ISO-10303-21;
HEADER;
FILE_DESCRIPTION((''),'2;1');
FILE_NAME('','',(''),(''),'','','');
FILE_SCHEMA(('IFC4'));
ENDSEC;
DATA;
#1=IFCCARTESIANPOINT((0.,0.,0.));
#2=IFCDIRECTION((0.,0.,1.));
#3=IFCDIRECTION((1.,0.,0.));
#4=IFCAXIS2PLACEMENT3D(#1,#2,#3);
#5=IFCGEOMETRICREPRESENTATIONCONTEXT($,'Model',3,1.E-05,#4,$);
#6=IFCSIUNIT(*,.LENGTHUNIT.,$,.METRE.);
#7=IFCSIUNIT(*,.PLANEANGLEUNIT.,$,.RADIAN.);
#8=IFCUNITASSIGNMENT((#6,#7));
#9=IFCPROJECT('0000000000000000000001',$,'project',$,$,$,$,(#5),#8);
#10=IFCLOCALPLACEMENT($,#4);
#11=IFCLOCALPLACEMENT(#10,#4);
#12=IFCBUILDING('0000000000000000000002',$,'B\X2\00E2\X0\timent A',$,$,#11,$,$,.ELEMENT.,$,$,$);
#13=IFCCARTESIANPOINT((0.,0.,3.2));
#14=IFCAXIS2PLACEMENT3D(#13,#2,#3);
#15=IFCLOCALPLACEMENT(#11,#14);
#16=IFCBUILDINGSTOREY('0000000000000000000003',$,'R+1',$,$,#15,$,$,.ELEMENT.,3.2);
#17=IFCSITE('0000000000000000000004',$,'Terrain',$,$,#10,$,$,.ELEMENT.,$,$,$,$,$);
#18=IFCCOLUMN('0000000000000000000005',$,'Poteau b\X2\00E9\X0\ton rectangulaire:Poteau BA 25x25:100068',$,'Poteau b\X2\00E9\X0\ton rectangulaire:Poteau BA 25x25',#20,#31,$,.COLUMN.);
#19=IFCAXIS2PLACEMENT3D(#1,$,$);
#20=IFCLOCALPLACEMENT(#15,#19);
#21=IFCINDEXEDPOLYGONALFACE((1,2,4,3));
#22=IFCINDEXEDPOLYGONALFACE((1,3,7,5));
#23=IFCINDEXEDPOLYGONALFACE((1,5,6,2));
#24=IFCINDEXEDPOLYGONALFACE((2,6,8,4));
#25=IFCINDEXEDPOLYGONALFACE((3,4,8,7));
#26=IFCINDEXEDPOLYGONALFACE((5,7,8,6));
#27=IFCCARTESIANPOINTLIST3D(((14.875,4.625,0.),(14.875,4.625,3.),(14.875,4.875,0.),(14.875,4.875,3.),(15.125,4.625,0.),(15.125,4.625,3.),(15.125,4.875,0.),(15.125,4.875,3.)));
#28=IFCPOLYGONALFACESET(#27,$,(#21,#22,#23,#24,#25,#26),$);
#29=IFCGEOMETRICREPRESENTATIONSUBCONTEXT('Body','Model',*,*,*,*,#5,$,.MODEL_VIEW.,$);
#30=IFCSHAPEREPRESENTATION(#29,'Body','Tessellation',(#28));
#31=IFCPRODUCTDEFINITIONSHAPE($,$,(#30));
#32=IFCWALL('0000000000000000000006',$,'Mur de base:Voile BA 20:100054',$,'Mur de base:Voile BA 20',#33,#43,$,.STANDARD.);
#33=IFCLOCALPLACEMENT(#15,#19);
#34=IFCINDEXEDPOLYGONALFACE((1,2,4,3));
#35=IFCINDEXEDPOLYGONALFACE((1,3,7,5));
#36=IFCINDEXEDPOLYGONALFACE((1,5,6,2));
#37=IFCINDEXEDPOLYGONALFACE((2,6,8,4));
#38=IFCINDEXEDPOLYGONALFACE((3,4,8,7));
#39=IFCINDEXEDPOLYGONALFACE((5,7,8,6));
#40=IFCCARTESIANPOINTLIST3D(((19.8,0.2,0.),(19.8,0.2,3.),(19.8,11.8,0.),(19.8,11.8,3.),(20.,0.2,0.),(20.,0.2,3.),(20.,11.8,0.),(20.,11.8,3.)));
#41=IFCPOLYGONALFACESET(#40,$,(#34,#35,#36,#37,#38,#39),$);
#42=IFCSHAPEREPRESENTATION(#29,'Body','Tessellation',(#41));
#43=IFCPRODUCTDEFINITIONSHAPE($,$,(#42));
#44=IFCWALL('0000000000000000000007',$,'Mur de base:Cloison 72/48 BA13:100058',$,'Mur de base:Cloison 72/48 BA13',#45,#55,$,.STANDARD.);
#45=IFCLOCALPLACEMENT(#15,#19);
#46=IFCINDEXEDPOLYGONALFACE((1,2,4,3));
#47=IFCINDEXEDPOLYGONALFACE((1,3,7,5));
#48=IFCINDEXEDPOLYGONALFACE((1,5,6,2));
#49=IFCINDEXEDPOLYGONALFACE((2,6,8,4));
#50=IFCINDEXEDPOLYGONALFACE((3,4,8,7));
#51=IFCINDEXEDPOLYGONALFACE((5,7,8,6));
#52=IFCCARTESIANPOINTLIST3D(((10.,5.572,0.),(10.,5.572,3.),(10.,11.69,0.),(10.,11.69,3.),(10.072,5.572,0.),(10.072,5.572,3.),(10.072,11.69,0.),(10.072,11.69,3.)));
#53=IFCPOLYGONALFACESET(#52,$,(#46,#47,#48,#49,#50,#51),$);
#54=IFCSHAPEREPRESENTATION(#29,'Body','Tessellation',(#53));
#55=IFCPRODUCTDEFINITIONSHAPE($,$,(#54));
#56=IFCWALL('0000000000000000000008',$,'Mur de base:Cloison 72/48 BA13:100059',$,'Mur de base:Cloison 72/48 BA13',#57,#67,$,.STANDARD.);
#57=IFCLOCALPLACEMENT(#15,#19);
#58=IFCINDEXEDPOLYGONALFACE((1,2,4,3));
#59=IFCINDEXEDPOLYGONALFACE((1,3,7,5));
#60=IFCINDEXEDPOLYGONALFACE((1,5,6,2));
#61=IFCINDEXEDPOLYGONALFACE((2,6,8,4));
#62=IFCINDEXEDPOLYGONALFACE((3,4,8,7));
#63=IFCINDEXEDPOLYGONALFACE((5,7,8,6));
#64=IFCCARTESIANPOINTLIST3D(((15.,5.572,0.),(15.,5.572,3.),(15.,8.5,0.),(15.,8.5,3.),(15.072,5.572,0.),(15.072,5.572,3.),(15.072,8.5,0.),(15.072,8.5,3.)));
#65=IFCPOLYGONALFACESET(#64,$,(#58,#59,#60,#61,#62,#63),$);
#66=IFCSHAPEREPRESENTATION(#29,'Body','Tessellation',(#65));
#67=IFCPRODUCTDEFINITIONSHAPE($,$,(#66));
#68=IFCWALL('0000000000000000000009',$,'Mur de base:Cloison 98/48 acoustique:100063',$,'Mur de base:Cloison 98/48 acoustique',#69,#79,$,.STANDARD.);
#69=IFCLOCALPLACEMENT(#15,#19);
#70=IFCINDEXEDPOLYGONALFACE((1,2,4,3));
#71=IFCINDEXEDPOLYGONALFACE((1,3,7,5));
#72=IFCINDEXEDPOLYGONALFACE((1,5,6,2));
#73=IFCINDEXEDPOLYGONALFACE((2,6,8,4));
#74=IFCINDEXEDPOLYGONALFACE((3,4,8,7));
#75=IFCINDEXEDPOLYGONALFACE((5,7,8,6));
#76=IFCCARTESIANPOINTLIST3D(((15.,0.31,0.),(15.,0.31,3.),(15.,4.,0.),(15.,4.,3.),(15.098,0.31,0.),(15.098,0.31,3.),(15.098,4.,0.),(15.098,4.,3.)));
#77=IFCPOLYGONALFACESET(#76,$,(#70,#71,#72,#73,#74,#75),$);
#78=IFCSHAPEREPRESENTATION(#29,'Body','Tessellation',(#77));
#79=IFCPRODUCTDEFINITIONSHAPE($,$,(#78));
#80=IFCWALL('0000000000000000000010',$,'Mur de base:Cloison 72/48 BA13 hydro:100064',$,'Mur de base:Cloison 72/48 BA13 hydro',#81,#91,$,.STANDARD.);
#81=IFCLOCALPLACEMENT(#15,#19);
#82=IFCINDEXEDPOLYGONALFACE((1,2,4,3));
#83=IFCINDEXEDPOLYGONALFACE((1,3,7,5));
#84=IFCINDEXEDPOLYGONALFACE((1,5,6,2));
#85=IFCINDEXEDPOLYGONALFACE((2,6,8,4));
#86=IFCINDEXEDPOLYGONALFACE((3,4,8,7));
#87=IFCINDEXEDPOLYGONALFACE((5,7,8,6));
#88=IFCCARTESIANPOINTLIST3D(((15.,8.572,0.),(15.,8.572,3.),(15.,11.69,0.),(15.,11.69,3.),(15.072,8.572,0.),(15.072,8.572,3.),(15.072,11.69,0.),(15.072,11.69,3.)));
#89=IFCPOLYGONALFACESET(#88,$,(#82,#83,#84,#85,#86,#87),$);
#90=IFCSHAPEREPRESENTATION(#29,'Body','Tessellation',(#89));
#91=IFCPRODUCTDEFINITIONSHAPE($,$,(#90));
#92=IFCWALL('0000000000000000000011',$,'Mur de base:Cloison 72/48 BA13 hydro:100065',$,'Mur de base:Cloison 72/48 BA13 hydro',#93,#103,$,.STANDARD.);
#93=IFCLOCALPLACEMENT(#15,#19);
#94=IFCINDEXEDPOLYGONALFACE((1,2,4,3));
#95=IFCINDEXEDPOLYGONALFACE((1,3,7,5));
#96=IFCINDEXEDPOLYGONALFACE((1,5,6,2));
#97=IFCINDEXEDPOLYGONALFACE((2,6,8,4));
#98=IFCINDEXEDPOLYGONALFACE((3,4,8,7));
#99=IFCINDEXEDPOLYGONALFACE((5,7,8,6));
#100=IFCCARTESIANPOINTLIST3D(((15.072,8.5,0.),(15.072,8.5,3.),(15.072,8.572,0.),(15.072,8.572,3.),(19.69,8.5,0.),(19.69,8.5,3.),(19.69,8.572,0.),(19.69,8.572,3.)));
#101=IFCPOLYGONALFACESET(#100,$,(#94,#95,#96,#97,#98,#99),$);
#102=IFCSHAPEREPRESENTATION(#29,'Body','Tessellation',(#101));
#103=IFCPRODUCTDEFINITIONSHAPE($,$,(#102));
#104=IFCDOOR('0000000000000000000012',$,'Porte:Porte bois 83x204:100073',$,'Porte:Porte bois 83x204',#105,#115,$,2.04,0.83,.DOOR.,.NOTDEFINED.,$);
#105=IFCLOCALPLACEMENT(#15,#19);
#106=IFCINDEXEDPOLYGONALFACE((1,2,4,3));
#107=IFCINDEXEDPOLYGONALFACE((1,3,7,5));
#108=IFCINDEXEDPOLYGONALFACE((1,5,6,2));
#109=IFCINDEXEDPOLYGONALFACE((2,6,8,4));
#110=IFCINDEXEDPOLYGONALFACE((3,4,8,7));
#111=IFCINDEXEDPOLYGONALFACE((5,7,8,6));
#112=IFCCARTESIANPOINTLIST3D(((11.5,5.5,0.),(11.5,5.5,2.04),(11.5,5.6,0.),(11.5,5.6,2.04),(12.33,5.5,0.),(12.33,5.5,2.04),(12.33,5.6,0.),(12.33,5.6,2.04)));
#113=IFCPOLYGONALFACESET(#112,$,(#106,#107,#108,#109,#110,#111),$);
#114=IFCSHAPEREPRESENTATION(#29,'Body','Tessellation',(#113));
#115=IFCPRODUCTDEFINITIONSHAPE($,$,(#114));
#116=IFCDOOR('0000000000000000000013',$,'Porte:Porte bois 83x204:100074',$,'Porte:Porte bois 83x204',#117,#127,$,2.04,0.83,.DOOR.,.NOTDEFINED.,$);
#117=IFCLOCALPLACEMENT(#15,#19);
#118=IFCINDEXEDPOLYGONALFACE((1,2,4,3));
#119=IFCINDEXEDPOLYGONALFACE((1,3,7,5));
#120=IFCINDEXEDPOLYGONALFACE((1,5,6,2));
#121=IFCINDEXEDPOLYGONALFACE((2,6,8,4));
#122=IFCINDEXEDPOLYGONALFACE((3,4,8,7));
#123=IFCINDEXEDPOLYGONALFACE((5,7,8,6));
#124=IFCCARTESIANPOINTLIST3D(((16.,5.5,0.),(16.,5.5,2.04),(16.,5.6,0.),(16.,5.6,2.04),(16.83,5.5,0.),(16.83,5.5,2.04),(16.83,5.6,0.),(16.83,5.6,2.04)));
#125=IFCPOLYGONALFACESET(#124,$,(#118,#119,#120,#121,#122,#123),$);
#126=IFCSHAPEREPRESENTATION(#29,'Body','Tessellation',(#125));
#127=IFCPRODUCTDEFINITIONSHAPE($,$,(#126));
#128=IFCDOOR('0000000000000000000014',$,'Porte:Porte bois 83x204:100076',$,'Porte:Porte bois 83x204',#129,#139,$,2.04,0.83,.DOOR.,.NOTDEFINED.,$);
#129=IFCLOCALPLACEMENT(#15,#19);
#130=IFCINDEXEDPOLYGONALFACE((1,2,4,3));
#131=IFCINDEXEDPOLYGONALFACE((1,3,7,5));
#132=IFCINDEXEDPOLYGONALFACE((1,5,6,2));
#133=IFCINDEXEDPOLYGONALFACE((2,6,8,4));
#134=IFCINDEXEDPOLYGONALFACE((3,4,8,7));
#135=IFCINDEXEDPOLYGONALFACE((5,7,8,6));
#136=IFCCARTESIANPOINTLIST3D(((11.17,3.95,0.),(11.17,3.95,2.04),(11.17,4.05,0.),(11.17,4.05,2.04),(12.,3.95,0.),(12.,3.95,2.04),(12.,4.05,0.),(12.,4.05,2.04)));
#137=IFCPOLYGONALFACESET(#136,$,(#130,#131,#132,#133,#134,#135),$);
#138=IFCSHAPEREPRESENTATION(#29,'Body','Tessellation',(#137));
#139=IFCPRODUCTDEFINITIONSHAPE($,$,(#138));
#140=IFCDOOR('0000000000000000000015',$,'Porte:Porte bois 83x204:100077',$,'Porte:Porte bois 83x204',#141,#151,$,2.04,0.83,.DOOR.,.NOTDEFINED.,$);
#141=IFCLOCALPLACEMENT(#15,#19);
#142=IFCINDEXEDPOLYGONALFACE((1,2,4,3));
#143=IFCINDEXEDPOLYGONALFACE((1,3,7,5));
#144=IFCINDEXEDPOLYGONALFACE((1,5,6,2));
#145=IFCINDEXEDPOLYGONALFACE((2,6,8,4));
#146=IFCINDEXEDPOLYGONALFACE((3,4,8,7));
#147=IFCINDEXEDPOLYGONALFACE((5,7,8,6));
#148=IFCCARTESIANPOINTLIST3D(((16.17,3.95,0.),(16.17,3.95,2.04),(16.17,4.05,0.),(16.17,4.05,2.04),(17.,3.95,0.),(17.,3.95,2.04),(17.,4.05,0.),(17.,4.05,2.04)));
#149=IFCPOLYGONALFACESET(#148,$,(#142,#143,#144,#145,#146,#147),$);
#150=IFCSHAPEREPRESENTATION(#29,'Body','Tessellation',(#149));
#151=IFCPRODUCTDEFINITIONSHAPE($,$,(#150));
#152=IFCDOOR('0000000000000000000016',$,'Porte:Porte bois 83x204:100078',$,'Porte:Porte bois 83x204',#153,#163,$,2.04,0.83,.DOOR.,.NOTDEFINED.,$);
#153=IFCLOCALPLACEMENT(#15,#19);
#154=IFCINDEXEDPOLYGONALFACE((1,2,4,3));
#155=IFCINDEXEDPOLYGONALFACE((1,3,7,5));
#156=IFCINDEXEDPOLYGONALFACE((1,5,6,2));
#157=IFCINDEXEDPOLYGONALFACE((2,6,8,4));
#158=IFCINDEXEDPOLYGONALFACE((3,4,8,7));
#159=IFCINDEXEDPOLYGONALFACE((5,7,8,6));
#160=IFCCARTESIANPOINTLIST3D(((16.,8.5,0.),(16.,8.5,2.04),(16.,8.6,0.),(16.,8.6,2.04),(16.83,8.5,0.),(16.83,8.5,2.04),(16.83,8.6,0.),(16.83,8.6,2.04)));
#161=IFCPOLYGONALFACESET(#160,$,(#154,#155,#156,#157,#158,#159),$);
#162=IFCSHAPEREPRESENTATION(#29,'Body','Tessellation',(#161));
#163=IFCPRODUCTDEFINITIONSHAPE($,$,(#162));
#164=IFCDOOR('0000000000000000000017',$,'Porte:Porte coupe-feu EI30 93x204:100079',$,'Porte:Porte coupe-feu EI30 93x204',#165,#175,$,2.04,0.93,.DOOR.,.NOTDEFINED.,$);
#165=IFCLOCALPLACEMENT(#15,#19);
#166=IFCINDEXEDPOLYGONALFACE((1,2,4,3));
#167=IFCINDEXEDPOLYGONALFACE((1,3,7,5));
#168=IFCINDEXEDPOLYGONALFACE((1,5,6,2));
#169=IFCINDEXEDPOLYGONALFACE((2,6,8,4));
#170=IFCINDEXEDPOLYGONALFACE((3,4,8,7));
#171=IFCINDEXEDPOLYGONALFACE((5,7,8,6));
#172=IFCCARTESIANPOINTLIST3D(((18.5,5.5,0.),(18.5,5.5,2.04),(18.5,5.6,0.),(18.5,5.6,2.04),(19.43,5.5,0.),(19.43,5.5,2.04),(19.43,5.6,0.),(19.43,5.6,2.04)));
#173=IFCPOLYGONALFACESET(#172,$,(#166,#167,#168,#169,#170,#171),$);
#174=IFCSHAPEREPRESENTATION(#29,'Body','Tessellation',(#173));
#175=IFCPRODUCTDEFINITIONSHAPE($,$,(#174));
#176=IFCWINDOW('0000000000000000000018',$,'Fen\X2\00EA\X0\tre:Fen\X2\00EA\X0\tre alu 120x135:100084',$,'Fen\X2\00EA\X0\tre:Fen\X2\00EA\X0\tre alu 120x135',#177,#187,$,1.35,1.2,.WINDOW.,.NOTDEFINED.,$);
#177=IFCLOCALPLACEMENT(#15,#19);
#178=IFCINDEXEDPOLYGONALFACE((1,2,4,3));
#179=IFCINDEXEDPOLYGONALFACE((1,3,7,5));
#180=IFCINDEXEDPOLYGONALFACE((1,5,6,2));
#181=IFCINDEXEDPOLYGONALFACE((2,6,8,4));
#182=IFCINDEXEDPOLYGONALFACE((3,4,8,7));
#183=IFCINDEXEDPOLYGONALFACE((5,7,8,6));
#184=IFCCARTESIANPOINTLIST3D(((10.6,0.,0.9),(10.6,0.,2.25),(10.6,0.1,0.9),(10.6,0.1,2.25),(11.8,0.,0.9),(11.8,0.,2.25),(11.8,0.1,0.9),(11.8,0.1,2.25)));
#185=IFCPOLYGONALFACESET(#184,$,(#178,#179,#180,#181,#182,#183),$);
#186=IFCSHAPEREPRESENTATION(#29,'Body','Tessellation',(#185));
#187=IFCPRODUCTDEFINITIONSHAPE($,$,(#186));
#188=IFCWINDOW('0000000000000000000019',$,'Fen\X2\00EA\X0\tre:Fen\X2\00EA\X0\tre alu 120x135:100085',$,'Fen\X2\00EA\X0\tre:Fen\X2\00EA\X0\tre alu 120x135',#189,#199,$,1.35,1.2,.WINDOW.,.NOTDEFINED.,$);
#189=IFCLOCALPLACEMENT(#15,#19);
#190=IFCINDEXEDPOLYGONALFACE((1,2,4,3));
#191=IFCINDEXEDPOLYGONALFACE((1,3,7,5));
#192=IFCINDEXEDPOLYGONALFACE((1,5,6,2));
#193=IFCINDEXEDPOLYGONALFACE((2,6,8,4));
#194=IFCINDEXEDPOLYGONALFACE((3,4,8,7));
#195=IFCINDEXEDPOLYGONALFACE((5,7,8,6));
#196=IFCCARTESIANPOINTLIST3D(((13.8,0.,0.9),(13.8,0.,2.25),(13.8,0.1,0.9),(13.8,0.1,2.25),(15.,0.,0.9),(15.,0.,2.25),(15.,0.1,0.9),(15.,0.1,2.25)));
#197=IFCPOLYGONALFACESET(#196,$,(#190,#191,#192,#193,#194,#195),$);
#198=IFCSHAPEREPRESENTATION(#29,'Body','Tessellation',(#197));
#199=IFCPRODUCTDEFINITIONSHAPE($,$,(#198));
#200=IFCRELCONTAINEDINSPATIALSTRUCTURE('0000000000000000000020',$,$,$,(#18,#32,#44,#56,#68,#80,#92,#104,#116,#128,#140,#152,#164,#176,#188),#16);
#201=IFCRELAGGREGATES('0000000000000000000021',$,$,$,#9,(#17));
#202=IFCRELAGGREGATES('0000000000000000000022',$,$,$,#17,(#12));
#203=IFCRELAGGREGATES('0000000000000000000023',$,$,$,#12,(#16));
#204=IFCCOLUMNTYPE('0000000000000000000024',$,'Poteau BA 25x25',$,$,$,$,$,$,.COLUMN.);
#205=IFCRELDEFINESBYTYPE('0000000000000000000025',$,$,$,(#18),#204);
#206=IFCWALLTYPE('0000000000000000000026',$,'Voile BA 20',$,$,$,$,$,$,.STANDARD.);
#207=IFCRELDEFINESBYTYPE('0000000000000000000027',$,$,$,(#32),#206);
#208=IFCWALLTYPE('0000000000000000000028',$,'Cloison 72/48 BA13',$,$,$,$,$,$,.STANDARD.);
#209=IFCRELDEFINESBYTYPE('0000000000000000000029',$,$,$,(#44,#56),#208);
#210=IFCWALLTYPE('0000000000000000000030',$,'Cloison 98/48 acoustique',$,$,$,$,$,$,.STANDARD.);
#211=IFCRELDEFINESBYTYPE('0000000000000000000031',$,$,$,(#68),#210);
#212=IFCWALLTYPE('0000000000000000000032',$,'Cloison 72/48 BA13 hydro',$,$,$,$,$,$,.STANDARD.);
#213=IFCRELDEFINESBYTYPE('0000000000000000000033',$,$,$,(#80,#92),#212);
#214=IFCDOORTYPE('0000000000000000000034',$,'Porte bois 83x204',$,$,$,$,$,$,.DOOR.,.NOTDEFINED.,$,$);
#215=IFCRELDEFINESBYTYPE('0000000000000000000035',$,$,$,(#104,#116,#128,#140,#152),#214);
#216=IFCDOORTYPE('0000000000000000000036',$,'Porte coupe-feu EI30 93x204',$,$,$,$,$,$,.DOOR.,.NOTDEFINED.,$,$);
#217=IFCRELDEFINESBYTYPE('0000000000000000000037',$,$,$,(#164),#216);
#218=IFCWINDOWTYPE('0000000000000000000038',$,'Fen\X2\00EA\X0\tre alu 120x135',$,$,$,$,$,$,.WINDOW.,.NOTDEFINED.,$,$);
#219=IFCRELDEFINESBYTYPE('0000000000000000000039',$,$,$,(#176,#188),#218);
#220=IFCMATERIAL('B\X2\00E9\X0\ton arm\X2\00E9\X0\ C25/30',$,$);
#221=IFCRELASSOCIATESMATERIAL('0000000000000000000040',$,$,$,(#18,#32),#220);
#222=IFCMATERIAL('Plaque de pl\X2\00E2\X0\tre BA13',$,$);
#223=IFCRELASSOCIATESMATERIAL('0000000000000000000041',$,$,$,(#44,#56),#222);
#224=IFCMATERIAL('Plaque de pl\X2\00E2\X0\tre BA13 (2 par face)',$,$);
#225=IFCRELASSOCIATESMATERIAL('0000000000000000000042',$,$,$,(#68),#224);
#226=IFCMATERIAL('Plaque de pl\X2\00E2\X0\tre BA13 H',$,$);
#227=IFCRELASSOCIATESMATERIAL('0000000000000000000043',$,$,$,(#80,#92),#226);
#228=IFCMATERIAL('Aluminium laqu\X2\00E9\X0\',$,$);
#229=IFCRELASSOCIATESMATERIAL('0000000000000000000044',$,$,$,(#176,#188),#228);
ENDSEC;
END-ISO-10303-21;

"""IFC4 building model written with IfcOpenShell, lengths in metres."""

from ifc_helpers import new_model, si_unit, frame, frame_2d, origin_with_axes, place, context, subcontext, project, spatial, rectangle, extrude, material, type_object, element, save


model = new_model("IFC4")

# Units and contexts
model_context = context("Model", 3, precision=1e-05, world=origin_with_axes())
body_context = subcontext(model_context, "Body", "Model", "MODEL_VIEW")
ifc_project = project(units=[si_unit("LENGTHUNIT", "METRE"), si_unit("PLANEANGLEUNIT", "RADIAN")], contexts=[model_context])

# Site, building, storey
site_placement = place(None, origin_with_axes())
site = spatial("IfcSite", under=ifc_project, at=site_placement, Name="Terrain", CompositionType="ELEMENT")
building_placement = place(site_placement, origin_with_axes())
building = spatial("IfcBuilding", under=site, at=building_placement, Name="Bâtiment A", CompositionType="ELEMENT")
storey_placement = place(building_placement, frame((0.0, 0.0, 3.2), z_axis=(0.0, 0.0, 1.0), x_axis=(1.0, 0.0, 0.0)))
storey = spatial("IfcBuildingStorey", under=building, at=storey_placement, Name="R+1", CompositionType="ELEMENT", Elevation=3.2)

# Column
ifc_material_1 = material(Name="Béton armé C25/30")
column_type = type_object("IfcColumnType", Name="Poteau BA 25x25", PredefinedType="COLUMN")
column_placement = place(storey_placement, frame((14.875, 4.625, 0.0), z_axis=(0.0, 0.0, 1.0), x_axis=(1.0, 0.0, 0.0)))
element("IfcColumn", 1, at=column_placement, inside=storey, type_object=column_type, material=ifc_material_1, Name="Poteau béton rectangulaire:Poteau BA 25x25:100068", ObjectType="Poteau béton rectangulaire:Poteau BA 25x25", PredefinedType="COLUMN", context=body_context, shape_type="SweptSolid", body=[
    extrude(rectangle(XDim=0.25, YDim=0.25, at=frame_2d((0.125, 0.125))), origin_with_axes(), (0.0, 0.0, 1.0), 3.0),
])

# Walls
wall_type_1 = type_object("IfcWallType", Name="Voile BA 20", PredefinedType="STANDARD")
wall_1_placement = place(storey_placement, frame((20.0, 0.2, 0.0), z_axis=(0.0, 0.0, 1.0), x_axis=(0.0, 1.0, 0.0)))
element("IfcWall", 2, at=wall_1_placement, inside=storey, type_object=wall_type_1, material=ifc_material_1, Name="Mur de base:Voile BA 20:100054", ObjectType="Mur de base:Voile BA 20", PredefinedType="STANDARD", context=body_context, shape_type="SweptSolid", body=[
    extrude(rectangle(XDim=11.6, YDim=0.2, at=frame_2d((5.8, 0.1))), origin_with_axes(), (0.0, 0.0, 1.0), 3.0),
])
ifc_material_2 = material(Name="Plaque de plâtre BA13")
wall_type_2 = type_object("IfcWallType", Name="Cloison 72/48 BA13", PredefinedType="STANDARD")
wall_2_placement = place(storey_placement, frame((10.072, 5.572, 0.0), z_axis=(0.0, 0.0, 1.0), x_axis=(0.0, 1.0, 0.0)))
element("IfcWall", 3, at=wall_2_placement, inside=storey, type_object=wall_type_2, material=ifc_material_2, Name="Mur de base:Cloison 72/48 BA13:100058", ObjectType="Mur de base:Cloison 72/48 BA13", PredefinedType="STANDARD", context=body_context, shape_type="SweptSolid", body=[
    extrude(rectangle(XDim=6.118, YDim=0.072, at=frame_2d((3.059, 0.036))), origin_with_axes(), (0.0, 0.0, 1.0), 3.0),
])
wall_3_placement = place(storey_placement, frame((15.072, 5.572, 0.0), z_axis=(0.0, 0.0, 1.0), x_axis=(0.0, 1.0, 0.0)))
element("IfcWall", 4, at=wall_3_placement, inside=storey, type_object=wall_type_2, material=ifc_material_2, Name="Mur de base:Cloison 72/48 BA13:100059", ObjectType="Mur de base:Cloison 72/48 BA13", PredefinedType="STANDARD", context=body_context, shape_type="SweptSolid", body=[
    extrude(rectangle(XDim=2.928, YDim=0.072, at=frame_2d((1.464, 0.036))), origin_with_axes(), (0.0, 0.0, 1.0), 3.0),
])
ifc_material_3 = material(Name="Plaque de plâtre BA13 (2 par face)")
wall_type_3 = type_object("IfcWallType", Name="Cloison 98/48 acoustique", PredefinedType="STANDARD")
wall_4_placement = place(storey_placement, frame((15.098, 0.31, 0.0), z_axis=(0.0, 0.0, 1.0), x_axis=(0.0, 1.0, 0.0)))
element("IfcWall", 5, at=wall_4_placement, inside=storey, type_object=wall_type_3, material=ifc_material_3, Name="Mur de base:Cloison 98/48 acoustique:100063", ObjectType="Mur de base:Cloison 98/48 acoustique", PredefinedType="STANDARD", context=body_context, shape_type="SweptSolid", body=[
    extrude(rectangle(XDim=3.69, YDim=0.098, at=frame_2d((1.845, 0.049))), origin_with_axes(), (0.0, 0.0, 1.0), 3.0),
])
ifc_material_4 = material(Name="Plaque de plâtre BA13 H")
wall_type_4 = type_object("IfcWallType", Name="Cloison 72/48 BA13 hydro", PredefinedType="STANDARD")
wall_5_placement = place(storey_placement, frame((15.072, 8.572, 0.0), z_axis=(0.0, 0.0, 1.0), x_axis=(0.0, 1.0, 0.0)))
element("IfcWall", 6, at=wall_5_placement, inside=storey, type_object=wall_type_4, material=ifc_material_4, Name="Mur de base:Cloison 72/48 BA13 hydro:100064", ObjectType="Mur de base:Cloison 72/48 BA13 hydro", PredefinedType="STANDARD", context=body_context, shape_type="SweptSolid", body=[
    extrude(rectangle(XDim=3.118, YDim=0.072, at=frame_2d((1.559, 0.036))), origin_with_axes(), (0.0, 0.0, 1.0), 3.0),
])
wall_6_placement = place(storey_placement, frame((15.072, 8.5, 0.0), z_axis=(0.0, 0.0, 1.0), x_axis=(1.0, 0.0, 0.0)))
element("IfcWall", 7, at=wall_6_placement, inside=storey, type_object=wall_type_4, material=ifc_material_4, Name="Mur de base:Cloison 72/48 BA13 hydro:100065", ObjectType="Mur de base:Cloison 72/48 BA13 hydro", PredefinedType="STANDARD", context=body_context, shape_type="SweptSolid", body=[
    extrude(rectangle(XDim=4.618, YDim=0.072, at=frame_2d((2.309, 0.036))), origin_with_axes(), (0.0, 0.0, 1.0), 3.0),
])

# Doors
door_type_1 = type_object("IfcDoorType", Name="Porte bois 83x204", OperationType="NOTDEFINED", PredefinedType="DOOR")
for number, where, z_axis, x_axis, name in (
    (8, (11.5, 5.5, 0.0), (0.0, 0.0, 1.0), (1.0, 0.0, 0.0), "Porte:Porte bois 83x204:100073"),
    (9, (16.0, 5.5, 0.0), (0.0, 0.0, 1.0), (1.0, 0.0, 0.0), "Porte:Porte bois 83x204:100074"),
    (10, (11.17, 3.95, 0.0), (0.0, 0.0, 1.0), (1.0, 0.0, 0.0), "Porte:Porte bois 83x204:100076"),
    (11, (16.17, 3.95, 0.0), (0.0, 0.0, 1.0), (1.0, 0.0, 0.0), "Porte:Porte bois 83x204:100077"),
    (12, (16.0, 8.5, 0.0), (0.0, 0.0, 1.0), (1.0, 0.0, 0.0), "Porte:Porte bois 83x204:100078"),
):
    element("IfcDoor", number, at=place(storey_placement, frame(where, z_axis=z_axis, x_axis=x_axis)), inside=storey, type_object=door_type_1, Name=name, ObjectType="Porte:Porte bois 83x204", OperationType="NOTDEFINED", OverallHeight=2.04, OverallWidth=0.83, PredefinedType="DOOR", context=body_context, shape_type="SweptSolid", body=[
        extrude(rectangle(XDim=0.83, YDim=0.1, at=frame_2d((0.415, 0.05))), origin_with_axes(), (0.0, 0.0, 1.0), 2.04),
    ])
door_type_2 = type_object("IfcDoorType", Name="Porte coupe-feu EI30 93x204", OperationType="NOTDEFINED", PredefinedType="DOOR")
door_placement = place(storey_placement, frame((18.5, 5.5, 0.0), z_axis=(0.0, 0.0, 1.0), x_axis=(1.0, 0.0, 0.0)))
element("IfcDoor", 13, at=door_placement, inside=storey, type_object=door_type_2, Name="Porte:Porte coupe-feu EI30 93x204:100079", ObjectType="Porte:Porte coupe-feu EI30 93x204", OperationType="NOTDEFINED", OverallHeight=2.04, OverallWidth=0.93, PredefinedType="DOOR", context=body_context, shape_type="SweptSolid", body=[
    extrude(rectangle(XDim=0.93, YDim=0.1, at=frame_2d((0.465, 0.05))), origin_with_axes(), (0.0, 0.0, 1.0), 2.04),
])

# Windows
ifc_material_5 = material(Name="Aluminium laqué")
window_type_1 = type_object("IfcWindowType", Name="Fenêtre alu 120x135", PartitioningType="NOTDEFINED", PredefinedType="WINDOW")
for number, where, z_axis, x_axis, name in (
    (14, (10.6, 0.0, 0.9), (0.0, 0.0, 1.0), (1.0, 0.0, 0.0), "Fenêtre:Fenêtre alu 120x135:100084"),
    (15, (13.8, 0.0, 0.9), (0.0, 0.0, 1.0), (1.0, 0.0, 0.0), "Fenêtre:Fenêtre alu 120x135:100085"),
):
    element("IfcWindow", number, at=place(storey_placement, frame(where, z_axis=z_axis, x_axis=x_axis)), inside=storey, type_object=window_type_1, material=ifc_material_5, Name=name, ObjectType="Fenêtre:Fenêtre alu 120x135", OverallHeight=1.35, OverallWidth=1.2, PartitioningType="NOTDEFINED", PredefinedType="WINDOW", context=body_context, shape_type="SweptSolid", body=[
        extrude(rectangle(XDim=1.2, YDim=0.1, at=frame_2d((0.6, 0.05))), origin_with_axes(), (0.0, 0.0, 1.0), 1.35),
    ])

save(model, "model.ifc")
